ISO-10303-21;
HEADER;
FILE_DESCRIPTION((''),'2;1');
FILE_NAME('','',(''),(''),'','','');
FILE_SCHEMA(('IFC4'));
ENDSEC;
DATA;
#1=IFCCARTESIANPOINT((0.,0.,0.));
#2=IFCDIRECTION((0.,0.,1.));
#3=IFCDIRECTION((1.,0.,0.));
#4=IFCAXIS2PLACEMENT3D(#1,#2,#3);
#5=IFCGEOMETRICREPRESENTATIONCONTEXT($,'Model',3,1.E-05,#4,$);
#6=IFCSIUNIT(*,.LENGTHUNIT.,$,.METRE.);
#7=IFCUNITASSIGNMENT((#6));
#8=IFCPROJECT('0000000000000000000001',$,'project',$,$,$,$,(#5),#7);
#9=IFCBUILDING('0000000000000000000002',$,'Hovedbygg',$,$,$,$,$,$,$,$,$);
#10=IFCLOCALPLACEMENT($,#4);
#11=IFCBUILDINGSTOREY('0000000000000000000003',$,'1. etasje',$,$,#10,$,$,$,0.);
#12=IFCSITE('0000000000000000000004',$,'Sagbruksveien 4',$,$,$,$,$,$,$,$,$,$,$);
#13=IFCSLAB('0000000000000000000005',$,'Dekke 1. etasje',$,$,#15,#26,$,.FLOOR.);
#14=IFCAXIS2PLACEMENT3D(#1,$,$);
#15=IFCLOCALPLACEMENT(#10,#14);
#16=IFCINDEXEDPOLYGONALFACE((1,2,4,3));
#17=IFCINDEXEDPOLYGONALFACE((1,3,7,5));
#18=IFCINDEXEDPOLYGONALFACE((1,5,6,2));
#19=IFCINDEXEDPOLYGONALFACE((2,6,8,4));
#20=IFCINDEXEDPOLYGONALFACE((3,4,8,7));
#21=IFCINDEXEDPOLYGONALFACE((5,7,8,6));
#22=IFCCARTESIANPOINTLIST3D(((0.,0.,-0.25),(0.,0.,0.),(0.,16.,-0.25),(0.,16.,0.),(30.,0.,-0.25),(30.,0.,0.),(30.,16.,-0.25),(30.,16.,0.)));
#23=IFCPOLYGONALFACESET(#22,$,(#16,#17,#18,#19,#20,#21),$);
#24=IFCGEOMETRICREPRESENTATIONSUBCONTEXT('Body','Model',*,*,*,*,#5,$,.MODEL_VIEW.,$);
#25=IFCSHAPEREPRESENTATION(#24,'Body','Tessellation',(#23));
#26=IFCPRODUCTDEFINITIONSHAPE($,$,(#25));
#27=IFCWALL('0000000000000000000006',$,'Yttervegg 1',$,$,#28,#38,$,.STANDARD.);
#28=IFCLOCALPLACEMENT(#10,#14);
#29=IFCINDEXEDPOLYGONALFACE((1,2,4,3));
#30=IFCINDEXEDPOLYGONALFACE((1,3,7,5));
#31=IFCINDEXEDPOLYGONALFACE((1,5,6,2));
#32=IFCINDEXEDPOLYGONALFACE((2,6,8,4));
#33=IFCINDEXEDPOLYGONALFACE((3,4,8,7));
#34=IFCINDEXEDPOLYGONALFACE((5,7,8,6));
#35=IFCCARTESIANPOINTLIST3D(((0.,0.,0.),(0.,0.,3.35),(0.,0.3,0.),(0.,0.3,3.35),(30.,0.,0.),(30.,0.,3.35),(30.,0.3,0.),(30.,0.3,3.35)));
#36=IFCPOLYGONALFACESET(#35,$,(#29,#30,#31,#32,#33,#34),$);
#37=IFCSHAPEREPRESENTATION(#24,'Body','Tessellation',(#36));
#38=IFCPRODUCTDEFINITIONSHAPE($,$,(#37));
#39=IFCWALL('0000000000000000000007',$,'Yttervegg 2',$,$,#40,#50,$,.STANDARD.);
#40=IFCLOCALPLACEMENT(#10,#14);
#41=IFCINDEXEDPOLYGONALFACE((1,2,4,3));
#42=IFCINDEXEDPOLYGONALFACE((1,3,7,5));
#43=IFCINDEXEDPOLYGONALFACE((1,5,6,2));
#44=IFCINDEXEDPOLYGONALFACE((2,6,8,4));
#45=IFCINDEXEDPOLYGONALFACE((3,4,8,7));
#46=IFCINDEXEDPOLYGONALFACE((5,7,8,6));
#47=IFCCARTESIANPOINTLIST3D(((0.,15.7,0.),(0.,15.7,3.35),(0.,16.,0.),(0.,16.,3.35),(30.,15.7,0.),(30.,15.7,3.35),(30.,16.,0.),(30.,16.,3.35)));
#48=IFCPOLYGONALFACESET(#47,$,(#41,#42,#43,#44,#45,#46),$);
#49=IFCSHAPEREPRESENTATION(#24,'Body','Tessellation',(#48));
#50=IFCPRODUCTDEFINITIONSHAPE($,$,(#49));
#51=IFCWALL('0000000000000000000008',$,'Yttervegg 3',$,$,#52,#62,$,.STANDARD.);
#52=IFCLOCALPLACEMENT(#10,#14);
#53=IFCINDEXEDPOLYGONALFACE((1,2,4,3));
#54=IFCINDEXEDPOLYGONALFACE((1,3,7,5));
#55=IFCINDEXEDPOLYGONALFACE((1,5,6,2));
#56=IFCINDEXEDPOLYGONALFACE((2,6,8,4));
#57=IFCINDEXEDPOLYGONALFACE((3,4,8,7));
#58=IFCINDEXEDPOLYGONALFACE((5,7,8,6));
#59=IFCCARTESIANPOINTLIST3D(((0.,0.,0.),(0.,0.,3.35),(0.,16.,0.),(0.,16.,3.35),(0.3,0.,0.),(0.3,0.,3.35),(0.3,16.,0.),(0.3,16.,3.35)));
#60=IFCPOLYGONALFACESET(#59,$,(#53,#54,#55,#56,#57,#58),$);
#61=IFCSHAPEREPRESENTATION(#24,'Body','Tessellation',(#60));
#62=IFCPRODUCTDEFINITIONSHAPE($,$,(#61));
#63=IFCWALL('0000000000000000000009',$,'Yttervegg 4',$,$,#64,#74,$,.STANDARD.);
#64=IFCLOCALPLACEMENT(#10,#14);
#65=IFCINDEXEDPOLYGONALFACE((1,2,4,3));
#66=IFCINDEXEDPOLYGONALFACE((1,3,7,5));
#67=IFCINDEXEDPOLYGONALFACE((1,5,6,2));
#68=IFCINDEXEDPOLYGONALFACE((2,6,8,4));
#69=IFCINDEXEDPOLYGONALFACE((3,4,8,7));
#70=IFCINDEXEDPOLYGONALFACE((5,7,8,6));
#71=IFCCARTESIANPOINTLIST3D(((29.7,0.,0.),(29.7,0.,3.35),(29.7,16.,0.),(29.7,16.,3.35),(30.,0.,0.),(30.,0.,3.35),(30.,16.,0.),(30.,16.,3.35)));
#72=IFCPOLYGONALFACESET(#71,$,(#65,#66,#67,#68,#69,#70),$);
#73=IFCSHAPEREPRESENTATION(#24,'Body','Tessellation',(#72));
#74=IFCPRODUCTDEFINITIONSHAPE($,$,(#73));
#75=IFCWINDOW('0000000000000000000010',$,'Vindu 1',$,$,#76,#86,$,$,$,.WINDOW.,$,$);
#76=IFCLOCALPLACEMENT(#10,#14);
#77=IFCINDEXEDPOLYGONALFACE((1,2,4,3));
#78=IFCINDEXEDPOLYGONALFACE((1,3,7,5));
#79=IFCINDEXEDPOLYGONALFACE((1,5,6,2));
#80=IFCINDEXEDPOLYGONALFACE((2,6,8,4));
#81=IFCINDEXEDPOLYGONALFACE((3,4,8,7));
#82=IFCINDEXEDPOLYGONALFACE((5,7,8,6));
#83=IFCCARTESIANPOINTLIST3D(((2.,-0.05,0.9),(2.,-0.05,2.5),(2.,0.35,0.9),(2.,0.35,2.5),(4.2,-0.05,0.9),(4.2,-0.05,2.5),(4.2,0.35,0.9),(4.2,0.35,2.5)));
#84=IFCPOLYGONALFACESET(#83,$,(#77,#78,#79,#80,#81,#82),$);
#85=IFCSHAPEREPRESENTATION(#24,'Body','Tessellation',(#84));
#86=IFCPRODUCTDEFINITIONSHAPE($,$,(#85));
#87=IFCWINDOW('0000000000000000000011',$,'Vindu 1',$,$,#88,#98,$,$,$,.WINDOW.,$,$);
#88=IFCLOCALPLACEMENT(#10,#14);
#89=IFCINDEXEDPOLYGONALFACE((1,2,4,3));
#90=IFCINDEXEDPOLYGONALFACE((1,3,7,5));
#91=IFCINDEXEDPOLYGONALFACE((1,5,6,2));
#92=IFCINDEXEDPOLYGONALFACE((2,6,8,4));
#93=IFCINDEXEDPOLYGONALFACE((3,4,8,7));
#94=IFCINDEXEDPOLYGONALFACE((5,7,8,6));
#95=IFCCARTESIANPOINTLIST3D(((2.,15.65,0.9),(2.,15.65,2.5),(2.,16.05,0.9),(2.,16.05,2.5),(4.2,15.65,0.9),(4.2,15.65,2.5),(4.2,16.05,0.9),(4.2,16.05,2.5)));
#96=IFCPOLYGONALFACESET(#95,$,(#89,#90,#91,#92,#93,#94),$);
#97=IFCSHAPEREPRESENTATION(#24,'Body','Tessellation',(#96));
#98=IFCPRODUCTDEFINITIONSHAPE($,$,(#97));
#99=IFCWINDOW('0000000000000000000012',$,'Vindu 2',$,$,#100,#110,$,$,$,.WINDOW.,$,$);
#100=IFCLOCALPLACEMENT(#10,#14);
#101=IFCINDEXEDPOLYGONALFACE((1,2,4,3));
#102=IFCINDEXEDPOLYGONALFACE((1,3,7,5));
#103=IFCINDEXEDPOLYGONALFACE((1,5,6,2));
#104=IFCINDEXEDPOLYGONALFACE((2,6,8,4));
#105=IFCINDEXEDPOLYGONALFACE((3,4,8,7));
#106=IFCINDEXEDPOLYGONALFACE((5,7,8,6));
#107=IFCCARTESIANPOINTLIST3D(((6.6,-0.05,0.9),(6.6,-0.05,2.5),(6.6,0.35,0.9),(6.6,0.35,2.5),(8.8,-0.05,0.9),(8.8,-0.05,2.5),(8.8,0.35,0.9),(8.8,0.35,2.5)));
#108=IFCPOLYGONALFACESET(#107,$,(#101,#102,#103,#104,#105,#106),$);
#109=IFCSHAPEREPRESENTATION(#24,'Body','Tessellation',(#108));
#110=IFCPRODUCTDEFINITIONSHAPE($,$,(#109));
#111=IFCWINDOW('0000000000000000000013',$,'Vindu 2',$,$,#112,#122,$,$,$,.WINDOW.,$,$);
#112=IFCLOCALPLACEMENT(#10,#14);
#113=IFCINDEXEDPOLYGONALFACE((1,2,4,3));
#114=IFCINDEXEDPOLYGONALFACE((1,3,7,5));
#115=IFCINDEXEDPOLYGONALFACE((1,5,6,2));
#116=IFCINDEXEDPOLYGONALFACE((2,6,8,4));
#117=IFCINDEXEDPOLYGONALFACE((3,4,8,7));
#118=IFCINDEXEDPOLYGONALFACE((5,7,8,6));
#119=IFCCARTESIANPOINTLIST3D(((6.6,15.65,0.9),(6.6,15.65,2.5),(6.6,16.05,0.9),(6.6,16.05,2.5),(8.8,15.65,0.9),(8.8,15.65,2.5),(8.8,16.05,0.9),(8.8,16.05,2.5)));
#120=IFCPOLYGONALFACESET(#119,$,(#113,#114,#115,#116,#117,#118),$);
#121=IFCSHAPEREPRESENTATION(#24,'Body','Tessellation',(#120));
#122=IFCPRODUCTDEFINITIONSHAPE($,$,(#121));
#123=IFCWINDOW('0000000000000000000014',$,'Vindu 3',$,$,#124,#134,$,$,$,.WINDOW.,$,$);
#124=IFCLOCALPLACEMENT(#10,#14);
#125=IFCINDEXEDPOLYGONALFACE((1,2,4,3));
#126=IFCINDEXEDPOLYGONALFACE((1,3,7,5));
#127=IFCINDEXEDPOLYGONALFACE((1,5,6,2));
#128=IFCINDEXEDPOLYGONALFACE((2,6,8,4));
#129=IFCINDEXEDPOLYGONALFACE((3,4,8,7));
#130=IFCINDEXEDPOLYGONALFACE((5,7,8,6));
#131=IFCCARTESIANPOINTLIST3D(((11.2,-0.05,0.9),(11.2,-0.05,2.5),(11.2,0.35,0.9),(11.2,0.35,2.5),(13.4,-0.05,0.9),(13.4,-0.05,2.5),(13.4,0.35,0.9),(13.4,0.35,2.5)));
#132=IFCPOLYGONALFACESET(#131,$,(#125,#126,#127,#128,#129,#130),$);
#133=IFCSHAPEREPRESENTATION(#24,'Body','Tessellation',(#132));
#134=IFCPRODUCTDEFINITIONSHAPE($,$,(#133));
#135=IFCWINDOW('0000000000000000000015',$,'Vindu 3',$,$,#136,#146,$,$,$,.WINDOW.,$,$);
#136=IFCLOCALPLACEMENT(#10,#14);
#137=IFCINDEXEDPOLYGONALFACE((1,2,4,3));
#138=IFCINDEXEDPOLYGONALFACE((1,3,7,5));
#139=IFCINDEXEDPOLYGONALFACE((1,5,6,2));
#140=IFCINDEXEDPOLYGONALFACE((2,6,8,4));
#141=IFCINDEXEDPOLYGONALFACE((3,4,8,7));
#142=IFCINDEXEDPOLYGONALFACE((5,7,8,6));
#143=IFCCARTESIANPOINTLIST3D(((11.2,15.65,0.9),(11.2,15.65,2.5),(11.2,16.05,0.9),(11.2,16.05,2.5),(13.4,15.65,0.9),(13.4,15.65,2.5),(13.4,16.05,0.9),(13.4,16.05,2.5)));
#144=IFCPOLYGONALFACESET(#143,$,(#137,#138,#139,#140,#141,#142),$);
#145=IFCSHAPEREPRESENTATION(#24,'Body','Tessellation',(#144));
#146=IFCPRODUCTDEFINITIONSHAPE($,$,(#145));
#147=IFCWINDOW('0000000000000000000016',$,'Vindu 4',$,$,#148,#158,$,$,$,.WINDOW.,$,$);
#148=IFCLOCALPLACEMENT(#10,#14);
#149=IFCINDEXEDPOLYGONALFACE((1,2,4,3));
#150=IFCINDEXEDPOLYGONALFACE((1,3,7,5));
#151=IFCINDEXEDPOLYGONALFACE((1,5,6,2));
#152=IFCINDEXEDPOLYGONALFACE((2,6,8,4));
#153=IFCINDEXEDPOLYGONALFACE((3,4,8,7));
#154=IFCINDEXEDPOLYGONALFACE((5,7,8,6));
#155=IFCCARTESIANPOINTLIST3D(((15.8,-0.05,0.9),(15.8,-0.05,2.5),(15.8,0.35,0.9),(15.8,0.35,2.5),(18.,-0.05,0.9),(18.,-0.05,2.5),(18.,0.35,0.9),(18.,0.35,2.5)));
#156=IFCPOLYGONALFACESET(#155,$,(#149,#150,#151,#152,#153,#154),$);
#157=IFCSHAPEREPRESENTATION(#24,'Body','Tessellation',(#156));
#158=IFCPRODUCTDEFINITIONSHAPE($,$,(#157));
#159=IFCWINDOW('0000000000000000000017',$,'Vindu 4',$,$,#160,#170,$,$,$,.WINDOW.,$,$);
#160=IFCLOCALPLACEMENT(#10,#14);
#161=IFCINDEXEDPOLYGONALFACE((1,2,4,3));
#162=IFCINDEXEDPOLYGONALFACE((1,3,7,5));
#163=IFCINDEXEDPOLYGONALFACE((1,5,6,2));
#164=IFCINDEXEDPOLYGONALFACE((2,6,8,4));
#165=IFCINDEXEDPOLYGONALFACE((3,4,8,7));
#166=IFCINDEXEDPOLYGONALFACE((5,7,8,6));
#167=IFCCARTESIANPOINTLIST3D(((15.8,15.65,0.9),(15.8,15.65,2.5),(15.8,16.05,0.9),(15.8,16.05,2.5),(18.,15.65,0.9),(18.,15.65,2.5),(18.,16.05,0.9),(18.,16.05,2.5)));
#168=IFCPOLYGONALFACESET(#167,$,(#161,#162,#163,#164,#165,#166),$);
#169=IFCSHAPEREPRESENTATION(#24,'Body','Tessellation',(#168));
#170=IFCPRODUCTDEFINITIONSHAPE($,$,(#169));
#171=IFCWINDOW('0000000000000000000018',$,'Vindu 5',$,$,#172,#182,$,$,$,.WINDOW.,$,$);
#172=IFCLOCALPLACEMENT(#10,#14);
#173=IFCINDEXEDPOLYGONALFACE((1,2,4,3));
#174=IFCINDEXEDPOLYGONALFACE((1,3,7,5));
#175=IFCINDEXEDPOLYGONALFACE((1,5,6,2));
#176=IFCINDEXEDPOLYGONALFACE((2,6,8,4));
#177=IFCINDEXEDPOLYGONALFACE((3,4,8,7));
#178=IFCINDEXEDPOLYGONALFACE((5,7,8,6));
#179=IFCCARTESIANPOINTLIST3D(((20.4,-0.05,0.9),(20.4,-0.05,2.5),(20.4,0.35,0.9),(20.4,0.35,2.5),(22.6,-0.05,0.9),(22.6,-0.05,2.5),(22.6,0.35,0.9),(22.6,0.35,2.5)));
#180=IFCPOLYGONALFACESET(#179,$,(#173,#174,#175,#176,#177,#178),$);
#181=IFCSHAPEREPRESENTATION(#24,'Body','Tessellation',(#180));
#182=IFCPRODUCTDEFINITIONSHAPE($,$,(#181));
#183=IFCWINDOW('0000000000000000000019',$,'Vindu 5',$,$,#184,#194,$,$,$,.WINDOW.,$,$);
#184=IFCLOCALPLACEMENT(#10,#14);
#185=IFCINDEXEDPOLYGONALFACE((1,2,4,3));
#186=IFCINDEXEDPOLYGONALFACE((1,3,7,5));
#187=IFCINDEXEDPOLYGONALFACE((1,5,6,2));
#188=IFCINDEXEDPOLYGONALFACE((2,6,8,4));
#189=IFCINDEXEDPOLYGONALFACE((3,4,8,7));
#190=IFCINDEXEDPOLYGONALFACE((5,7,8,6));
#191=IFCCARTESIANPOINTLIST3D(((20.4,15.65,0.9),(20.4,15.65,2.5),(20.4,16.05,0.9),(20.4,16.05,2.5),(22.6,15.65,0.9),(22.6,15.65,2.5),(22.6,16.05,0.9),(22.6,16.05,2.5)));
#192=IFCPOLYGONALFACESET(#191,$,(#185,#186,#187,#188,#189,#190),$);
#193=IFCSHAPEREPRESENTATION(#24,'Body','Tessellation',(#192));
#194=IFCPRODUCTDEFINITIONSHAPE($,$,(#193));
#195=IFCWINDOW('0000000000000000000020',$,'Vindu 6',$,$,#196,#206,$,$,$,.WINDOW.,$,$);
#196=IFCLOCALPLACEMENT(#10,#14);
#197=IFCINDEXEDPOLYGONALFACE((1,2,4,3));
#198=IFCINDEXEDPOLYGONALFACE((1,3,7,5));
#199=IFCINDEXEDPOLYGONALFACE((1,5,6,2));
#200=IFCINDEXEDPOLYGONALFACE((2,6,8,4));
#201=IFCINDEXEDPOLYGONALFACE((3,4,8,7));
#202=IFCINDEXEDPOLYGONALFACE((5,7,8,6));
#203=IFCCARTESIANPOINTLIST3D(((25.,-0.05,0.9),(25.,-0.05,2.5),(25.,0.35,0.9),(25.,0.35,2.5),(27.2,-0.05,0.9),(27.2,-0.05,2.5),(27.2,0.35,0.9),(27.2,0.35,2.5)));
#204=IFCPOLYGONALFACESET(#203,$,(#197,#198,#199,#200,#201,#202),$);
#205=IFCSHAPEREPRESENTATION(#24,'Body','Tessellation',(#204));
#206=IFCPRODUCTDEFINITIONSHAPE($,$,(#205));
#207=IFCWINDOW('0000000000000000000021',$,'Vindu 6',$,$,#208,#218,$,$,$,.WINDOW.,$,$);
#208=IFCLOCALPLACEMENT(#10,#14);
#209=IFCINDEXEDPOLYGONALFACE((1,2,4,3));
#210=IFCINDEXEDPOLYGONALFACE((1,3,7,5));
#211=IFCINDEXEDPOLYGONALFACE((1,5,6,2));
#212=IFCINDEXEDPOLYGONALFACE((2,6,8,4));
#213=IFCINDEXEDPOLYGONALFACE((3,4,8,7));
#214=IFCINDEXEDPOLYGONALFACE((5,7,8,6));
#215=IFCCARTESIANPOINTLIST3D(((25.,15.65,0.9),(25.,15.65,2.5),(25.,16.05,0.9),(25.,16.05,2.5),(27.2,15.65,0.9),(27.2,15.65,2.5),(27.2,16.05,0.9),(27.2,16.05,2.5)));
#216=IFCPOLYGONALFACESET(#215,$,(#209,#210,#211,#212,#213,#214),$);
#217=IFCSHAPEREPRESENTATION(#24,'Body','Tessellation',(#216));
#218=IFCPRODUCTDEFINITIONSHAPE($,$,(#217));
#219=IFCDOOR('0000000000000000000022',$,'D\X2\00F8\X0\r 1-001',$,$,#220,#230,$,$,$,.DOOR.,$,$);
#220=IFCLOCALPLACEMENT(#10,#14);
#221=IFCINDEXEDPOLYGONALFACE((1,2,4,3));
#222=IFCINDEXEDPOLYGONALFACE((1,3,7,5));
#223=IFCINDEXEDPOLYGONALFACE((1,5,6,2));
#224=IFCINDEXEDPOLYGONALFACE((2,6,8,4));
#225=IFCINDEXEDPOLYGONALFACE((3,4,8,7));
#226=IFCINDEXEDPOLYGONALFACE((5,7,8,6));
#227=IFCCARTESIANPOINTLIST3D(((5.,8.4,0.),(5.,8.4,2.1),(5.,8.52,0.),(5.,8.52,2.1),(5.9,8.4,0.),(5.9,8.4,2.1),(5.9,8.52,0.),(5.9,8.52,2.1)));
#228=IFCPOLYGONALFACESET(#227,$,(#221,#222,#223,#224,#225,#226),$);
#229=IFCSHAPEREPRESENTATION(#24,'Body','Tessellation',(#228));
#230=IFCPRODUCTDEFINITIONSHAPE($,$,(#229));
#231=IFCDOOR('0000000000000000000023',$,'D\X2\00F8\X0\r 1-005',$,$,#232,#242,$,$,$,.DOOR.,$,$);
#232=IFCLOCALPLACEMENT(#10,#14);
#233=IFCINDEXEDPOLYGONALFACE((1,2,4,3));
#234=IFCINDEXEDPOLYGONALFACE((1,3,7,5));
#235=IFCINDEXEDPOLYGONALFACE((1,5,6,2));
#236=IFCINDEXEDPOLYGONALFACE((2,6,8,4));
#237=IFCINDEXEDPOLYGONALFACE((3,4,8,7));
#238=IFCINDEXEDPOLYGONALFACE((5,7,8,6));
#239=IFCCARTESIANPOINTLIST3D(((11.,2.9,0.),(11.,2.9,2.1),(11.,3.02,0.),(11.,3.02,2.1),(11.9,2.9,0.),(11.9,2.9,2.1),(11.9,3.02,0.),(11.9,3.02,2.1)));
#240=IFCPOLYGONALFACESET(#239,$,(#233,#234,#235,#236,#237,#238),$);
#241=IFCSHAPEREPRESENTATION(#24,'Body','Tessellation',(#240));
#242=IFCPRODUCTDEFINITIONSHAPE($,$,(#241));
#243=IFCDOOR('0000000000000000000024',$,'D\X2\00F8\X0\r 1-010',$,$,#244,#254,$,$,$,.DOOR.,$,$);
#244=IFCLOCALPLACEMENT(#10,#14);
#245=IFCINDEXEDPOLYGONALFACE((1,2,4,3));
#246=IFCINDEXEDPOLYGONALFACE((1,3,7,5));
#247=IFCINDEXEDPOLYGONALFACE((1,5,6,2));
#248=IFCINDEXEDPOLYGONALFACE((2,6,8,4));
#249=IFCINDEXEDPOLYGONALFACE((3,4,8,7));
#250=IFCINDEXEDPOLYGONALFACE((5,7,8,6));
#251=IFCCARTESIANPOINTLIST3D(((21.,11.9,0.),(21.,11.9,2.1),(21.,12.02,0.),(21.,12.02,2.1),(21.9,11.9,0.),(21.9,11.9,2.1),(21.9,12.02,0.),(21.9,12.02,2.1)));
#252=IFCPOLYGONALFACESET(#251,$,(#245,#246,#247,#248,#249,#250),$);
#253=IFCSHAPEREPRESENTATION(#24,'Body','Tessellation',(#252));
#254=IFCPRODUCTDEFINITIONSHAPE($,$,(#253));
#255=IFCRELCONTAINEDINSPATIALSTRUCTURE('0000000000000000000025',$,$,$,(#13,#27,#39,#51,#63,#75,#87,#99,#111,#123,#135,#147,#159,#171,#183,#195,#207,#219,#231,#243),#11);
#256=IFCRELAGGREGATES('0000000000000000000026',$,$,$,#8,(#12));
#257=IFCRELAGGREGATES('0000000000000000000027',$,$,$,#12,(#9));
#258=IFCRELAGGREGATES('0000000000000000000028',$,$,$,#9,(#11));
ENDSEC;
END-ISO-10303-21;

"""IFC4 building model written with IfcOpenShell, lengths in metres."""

from ifc_helpers import new_model, si_unit, frame, origin_with_axes, place, context, subcontext, project, spatial, line, indexed_curve, outline, extrude, element, save


model = new_model("IFC4")

# Units and contexts
model_context = context("Model", 3, precision=1e-05, world=origin_with_axes())
body_context = subcontext(model_context, "Body", "Model", "MODEL_VIEW")
ifc_project = project(units=[si_unit("LENGTHUNIT", "METRE")], contexts=[model_context])

# Site, building, storey
site = spatial("IfcSite", under=ifc_project, Name="Sagbruksveien 4")
building = spatial("IfcBuilding", under=site, Name="Hovedbygg")
storey_placement = place(None, origin_with_axes())
storey = spatial("IfcBuildingStorey", under=building, at=storey_placement, Name="1. etasje", Elevation=0.0)

# Slab
slab_placement = place(storey_placement, frame((0.0, 0.0, -0.25), z_axis=(0.0, 0.0, 1.0), x_axis=(1.0, 0.0, 0.0)))
element("IfcSlab", 1, at=slab_placement, inside=storey, Name="Dekke 1. etasje", PredefinedType="FLOOR", context=body_context, shape_type="SweptSolid", body=[
    extrude(outline(indexed_curve([(0.0, 0.0), (30.0, 0.0), (30.0, 16.0), (0.0, 16.0)], segments=[line(1, 2, 3, 4, 1)])), origin_with_axes(), (0.0, 0.0, 1.0), 0.25),
])

# Walls
for number, where, z_axis, x_axis, name in (
    (2, (0.0, 0.0, 0.0), (0.0, 0.0, 1.0), (1.0, 0.0, 0.0), "Yttervegg 1"),
    (3, (0.0, 15.7, 0.0), (0.0, 0.0, 1.0), (1.0, 0.0, 0.0), "Yttervegg 2"),
):
    element("IfcWall", number, at=place(storey_placement, frame(where, z_axis=z_axis, x_axis=x_axis)), inside=storey, Name=name, PredefinedType="STANDARD", context=body_context, shape_type="SweptSolid", body=[
        extrude(outline(indexed_curve([(0.0, 0.0), (30.0, 0.0), (30.0, 0.3), (0.0, 0.3)], segments=[line(1, 2, 3, 4, 1)])), origin_with_axes(), (0.0, 0.0, 1.0), 3.35),
    ])
for number, where, z_axis, x_axis, name in (
    (4, (0.0, 0.0, 0.0), (0.0, 0.0, 1.0), (1.0, 0.0, 0.0), "Yttervegg 3"),
    (5, (29.7, 0.0, 0.0), (0.0, 0.0, 1.0), (1.0, 0.0, 0.0), "Yttervegg 4"),
):
    element("IfcWall", number, at=place(storey_placement, frame(where, z_axis=z_axis, x_axis=x_axis)), inside=storey, Name=name, PredefinedType="STANDARD", context=body_context, shape_type="SweptSolid", body=[
        extrude(outline(indexed_curve([(0.0, 0.0), (0.3, 0.0), (0.3, 16.0), (0.0, 16.0)], segments=[line(1, 2, 3, 4, 1)])), origin_with_axes(), (0.0, 0.0, 1.0), 3.35),
    ])

# Windows
for number, where, z_axis, x_axis, name in (
    (6, (2.0, -0.05, 0.9), (0.0, 0.0, 1.0), (1.0, 0.0, 0.0), "Vindu 1"),
    (7, (2.0, 15.65, 0.9), (0.0, 0.0, 1.0), (1.0, 0.0, 0.0), "Vindu 1"),
    (8, (6.6, -0.05, 0.9), (0.0, 0.0, 1.0), (1.0, 0.0, 0.0), "Vindu 2"),
    (9, (6.6, 15.65, 0.9), (0.0, 0.0, 1.0), (1.0, 0.0, 0.0), "Vindu 2"),
    (10, (11.2, -0.05, 0.9), (0.0, 0.0, 1.0), (1.0, 0.0, 0.0), "Vindu 3"),
    (11, (11.2, 15.65, 0.9), (0.0, 0.0, 1.0), (1.0, 0.0, 0.0), "Vindu 3"),
    (12, (15.8, -0.05, 0.9), (0.0, 0.0, 1.0), (1.0, 0.0, 0.0), "Vindu 4"),
    (13, (15.8, 15.65, 0.9), (0.0, 0.0, 1.0), (1.0, 0.0, 0.0), "Vindu 4"),
    (14, (20.4, -0.05, 0.9), (0.0, 0.0, 1.0), (1.0, 0.0, 0.0), "Vindu 5"),
    (15, (20.4, 15.65, 0.9), (0.0, 0.0, 1.0), (1.0, 0.0, 0.0), "Vindu 5"),
    (16, (25.0, -0.05, 0.9), (0.0, 0.0, 1.0), (1.0, 0.0, 0.0), "Vindu 6"),
    (17, (25.0, 15.65, 0.9), (0.0, 0.0, 1.0), (1.0, 0.0, 0.0), "Vindu 6"),
):
    element("IfcWindow", number, at=place(storey_placement, frame(where, z_axis=z_axis, x_axis=x_axis)), inside=storey, Name=name, PredefinedType="WINDOW", context=body_context, shape_type="SweptSolid", body=[
        extrude(outline(indexed_curve([(0.0, 0.0), (2.2, 0.0), (2.2, 0.4), (0.0, 0.4)], segments=[line(1, 2, 3, 4, 1)])), origin_with_axes(), (0.0, 0.0, 1.0), 1.6),
    ])

# Doors
for number, where, z_axis, x_axis, name in (
    (18, (5.0, 8.4, 0.0), (0.0, 0.0, 1.0), (1.0, 0.0, 0.0), "Dør 1-001"),
    (19, (11.0, 2.9, 0.0), (0.0, 0.0, 1.0), (1.0, 0.0, 0.0), "Dør 1-005"),
    (20, (21.0, 11.9, 0.0), (0.0, 0.0, 1.0), (1.0, 0.0, 0.0), "Dør 1-010"),
):
    element("IfcDoor", number, at=place(storey_placement, frame(where, z_axis=z_axis, x_axis=x_axis)), inside=storey, Name=name, PredefinedType="DOOR", context=body_context, shape_type="SweptSolid", body=[
        extrude(outline(indexed_curve([(0.0, 0.0), (0.9, 0.0), (0.9, 0.12), (0.0, 0.12)], segments=[line(1, 2, 3, 4, 1)])), origin_with_axes(), (0.0, 0.0, 1.0), 2.1),
    ])

save(model, "model.ifc")
